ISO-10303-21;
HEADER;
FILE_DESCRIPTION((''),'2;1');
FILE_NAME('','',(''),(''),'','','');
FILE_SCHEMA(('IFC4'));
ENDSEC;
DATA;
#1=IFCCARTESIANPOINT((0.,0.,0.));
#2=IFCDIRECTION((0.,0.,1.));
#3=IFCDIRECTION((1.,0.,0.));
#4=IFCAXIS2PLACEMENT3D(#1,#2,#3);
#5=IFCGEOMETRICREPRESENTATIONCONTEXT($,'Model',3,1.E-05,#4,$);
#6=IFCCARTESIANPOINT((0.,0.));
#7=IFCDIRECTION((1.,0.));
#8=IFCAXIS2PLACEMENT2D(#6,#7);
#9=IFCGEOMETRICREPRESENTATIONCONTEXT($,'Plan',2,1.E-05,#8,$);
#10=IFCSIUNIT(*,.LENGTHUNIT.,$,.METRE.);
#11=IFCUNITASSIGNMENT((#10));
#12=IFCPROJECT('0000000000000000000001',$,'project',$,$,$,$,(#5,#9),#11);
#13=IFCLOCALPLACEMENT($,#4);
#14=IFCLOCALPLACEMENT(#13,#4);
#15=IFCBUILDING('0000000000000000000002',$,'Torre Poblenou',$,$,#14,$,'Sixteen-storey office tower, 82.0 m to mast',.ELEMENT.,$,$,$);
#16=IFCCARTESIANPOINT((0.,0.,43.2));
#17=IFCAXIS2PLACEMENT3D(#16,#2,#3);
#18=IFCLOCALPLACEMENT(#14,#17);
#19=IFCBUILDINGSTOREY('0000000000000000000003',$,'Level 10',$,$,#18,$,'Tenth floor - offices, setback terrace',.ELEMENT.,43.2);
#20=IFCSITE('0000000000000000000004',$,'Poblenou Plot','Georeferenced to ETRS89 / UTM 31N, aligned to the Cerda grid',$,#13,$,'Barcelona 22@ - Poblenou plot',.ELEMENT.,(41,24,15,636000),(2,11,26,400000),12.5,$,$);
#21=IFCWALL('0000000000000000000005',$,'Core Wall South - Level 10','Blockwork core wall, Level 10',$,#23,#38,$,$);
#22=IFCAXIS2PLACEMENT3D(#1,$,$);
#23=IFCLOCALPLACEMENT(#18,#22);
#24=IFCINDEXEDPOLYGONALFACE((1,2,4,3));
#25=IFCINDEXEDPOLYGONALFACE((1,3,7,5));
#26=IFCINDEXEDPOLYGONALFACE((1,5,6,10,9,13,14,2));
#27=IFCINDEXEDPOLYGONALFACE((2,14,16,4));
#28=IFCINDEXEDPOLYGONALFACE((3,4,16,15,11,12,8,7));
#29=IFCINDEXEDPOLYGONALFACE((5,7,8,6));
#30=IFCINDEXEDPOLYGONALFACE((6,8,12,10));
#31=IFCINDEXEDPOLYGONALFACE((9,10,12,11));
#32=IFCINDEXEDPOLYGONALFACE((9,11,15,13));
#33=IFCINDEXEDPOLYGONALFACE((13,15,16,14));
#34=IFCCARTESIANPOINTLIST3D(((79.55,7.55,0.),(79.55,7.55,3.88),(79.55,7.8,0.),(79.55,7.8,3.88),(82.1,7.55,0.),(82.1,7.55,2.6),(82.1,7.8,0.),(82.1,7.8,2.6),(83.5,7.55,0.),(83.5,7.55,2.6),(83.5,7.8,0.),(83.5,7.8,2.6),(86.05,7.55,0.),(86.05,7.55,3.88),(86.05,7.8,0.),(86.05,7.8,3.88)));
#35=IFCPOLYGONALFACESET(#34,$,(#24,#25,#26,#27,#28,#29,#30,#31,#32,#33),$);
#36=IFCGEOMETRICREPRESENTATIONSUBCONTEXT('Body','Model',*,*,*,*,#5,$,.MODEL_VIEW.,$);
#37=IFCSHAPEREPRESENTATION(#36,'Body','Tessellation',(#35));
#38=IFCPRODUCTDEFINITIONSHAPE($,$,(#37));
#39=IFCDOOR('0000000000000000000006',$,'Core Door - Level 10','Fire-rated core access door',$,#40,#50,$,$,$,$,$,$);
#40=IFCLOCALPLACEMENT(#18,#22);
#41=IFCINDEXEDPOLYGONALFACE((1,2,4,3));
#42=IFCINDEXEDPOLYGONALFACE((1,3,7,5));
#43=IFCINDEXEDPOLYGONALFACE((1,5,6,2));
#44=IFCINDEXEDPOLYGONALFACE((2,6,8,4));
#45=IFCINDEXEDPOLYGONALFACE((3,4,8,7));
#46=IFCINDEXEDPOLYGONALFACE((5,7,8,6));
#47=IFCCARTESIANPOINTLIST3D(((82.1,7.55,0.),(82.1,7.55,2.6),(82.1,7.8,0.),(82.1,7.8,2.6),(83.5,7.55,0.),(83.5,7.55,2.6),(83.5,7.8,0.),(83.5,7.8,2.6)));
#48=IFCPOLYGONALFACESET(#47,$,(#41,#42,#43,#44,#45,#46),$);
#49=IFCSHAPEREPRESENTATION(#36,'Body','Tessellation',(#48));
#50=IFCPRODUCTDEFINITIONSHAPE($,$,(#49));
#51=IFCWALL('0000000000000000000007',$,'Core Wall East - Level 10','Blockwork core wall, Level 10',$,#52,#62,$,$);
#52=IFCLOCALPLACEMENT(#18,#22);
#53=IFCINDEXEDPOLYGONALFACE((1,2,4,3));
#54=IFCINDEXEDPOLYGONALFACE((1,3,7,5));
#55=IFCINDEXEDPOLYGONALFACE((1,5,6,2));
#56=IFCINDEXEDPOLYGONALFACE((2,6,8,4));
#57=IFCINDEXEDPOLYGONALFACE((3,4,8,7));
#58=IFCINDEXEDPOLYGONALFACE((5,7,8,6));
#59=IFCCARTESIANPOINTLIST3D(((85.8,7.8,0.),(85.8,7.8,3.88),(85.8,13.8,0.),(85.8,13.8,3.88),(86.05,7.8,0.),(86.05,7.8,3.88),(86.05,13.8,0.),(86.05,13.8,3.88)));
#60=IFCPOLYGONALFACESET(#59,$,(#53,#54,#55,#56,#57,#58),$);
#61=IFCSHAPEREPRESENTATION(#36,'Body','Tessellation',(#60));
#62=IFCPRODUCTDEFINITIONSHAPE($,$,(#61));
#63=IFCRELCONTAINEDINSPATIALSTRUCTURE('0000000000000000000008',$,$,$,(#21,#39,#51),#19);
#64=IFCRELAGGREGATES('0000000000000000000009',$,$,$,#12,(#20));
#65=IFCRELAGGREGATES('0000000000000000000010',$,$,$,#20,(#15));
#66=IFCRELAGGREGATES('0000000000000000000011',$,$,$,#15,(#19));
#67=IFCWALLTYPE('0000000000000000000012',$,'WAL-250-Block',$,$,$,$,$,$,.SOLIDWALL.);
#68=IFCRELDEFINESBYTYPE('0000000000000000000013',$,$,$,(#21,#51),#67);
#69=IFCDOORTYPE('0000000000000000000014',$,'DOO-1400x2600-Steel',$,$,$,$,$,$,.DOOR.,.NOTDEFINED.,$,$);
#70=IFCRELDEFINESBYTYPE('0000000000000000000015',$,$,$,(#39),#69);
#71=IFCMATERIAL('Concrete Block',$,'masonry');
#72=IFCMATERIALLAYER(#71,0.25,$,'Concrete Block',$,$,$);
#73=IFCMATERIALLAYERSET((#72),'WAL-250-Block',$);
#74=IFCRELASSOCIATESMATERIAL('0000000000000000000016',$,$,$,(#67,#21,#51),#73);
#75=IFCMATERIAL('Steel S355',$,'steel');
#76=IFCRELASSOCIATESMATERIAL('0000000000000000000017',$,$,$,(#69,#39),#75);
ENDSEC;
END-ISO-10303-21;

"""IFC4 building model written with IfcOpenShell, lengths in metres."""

from ifc_helpers import new_model, si_unit, frame, origin_with_axes, origin_2d_with_axis, place, context, subcontext, project, spatial, line, indexed_curve, outline, extrude, material, layer, layer_set, layer_usage, type_object, element, fill, save


model = new_model("IFC4")

# Units and contexts
model_context = context("Model", 3, precision=1e-05, world=origin_with_axes())
plan_context = context("Plan", 2, precision=1e-05, world=origin_2d_with_axis())
body_context = subcontext(model_context, "Body", "Model", "MODEL_VIEW")
ifc_project = project(units=[si_unit("LENGTHUNIT", "METRE")], contexts=[model_context, plan_context])

# Site, building, storey
site_placement = place(None, origin_with_axes())
site = spatial("IfcSite", under=ifc_project, at=site_placement, Name="Poblenou Plot", Description="Georeferenced to ETRS89 / UTM 31N, aligned to the Cerda grid", LongName="Barcelona 22@ - Poblenou plot", CompositionType="ELEMENT", RefLatitude=(41, 24, 15, 636000), RefLongitude=(2, 11, 26, 400000), RefElevation=12.5)
building_placement = place(site_placement, origin_with_axes())
building = spatial("IfcBuilding", under=site, at=building_placement, Name="Torre Poblenou", LongName="Sixteen-storey office tower, 82.0 m to mast", CompositionType="ELEMENT")
storey_placement = place(building_placement, frame((0.0, 0.0, 43.2), z_axis=(0.0, 0.0, 1.0), x_axis=(1.0, 0.0, 0.0)))
storey = spatial("IfcBuildingStorey", under=building, at=storey_placement, Name="Level 10", LongName="Tenth floor - offices, setback terrace", CompositionType="ELEMENT", Elevation=43.2)

# Wall, opening, door
ifc_material_1 = material(Name="Concrete Block", Category="masonry")
ifc_layer_1 = layer(ifc_material_1, 0.25, Name="Concrete Block")
ifc_layer_set_1 = layer_set([ifc_layer_1], Name="WAL-250-Block")
ifc_layer_usage_1 = layer_usage(ifc_layer_set_1, "AXIS2", "POSITIVE", 0.0)
wall_type = type_object("IfcWallType", Name="WAL-250-Block", PredefinedType="SOLIDWALL", material=ifc_layer_set_1)
wall_1_placement = place(storey_placement, frame((86.05, 7.8, 0.0), z_axis=(0.0, 0.0, 1.0), x_axis=(-1.0, 0.0, 0.0)))
wall_1 = element("IfcWall", 1, at=wall_1_placement, inside=storey, type_object=wall_type, material=ifc_layer_usage_1, Name="Core Wall South - Level 10", Description="Blockwork core wall, Level 10", context=body_context, shape_type="SweptSolid", body=[
    extrude(outline(indexed_curve([(0.0, 0.0), (6.5, 0.0), (6.5, 0.25), (0.0, 0.25)], segments=[line(1, 2, 3, 4, 1)])), origin_with_axes(), (0.0, 0.0, 1.0), 3.88),
])
opening_placement = place(wall_1_placement, frame((2.55, -0.05, 0.0), z_axis=(0.0, 0.0, 1.0), x_axis=(1.0, 0.0, 0.0)))
opening = element("IfcOpeningElement", 2, at=opening_placement, cuts=wall_1, PredefinedType="OPENING", context=body_context, shape_type="SweptSolid", body=[
    extrude(outline(indexed_curve([(0.0, 0.0), (1.4, 0.0), (1.4, 0.35), (0.0, 0.35)], segments=[line(1, 2, 3, 4, 1)])), origin_with_axes(), (0.0, 0.0, 1.0), 2.6),
])
ifc_material_2 = material(Name="Steel S355", Category="steel")
door_type = type_object("IfcDoorType", Name="DOO-1400x2600-Steel", OperationType="NOTDEFINED", PredefinedType="DOOR", material=ifc_material_2)
door_placement = place(storey_placement, frame((83.5, 7.8, 0.0), z_axis=(0.0, 0.0, 1.0), x_axis=(-1.0, 0.0, 0.0)))
door = element("IfcDoor", 3, at=door_placement, inside=storey, type_object=door_type, material=ifc_material_2, Name="Core Door - Level 10", Description="Fire-rated core access door", context=body_context, shape_type="SweptSolid", body=[
    extrude(outline(indexed_curve([(0.0, 0.0), (1.4, 0.0), (1.4, 0.25), (0.0, 0.25)], segments=[line(1, 2, 3, 4, 1)])), origin_with_axes(), (0.0, 0.0, 1.0), 2.6),
])
fill(opening, door)

# Wall
ifc_layer_usage_2 = layer_usage(ifc_layer_set_1, "AXIS2", "POSITIVE", 0.0)
wall_2_placement = place(storey_placement, frame((85.8, 13.8, 0.0), z_axis=(0.0, 0.0, 1.0), x_axis=(0.0, -1.0, 0.0)))
element("IfcWall", 4, at=wall_2_placement, inside=storey, type_object=wall_type, material=ifc_layer_usage_2, Name="Core Wall East - Level 10", Description="Blockwork core wall, Level 10", context=body_context, shape_type="SweptSolid", body=[
    extrude(outline(indexed_curve([(0.0, 0.0), (6.0, 0.0), (6.0, 0.25), (0.0, 0.25)], segments=[line(1, 2, 3, 4, 1)])), origin_with_axes(), (0.0, 0.0, 1.0), 3.88),
])

save(model, "model.ifc")
